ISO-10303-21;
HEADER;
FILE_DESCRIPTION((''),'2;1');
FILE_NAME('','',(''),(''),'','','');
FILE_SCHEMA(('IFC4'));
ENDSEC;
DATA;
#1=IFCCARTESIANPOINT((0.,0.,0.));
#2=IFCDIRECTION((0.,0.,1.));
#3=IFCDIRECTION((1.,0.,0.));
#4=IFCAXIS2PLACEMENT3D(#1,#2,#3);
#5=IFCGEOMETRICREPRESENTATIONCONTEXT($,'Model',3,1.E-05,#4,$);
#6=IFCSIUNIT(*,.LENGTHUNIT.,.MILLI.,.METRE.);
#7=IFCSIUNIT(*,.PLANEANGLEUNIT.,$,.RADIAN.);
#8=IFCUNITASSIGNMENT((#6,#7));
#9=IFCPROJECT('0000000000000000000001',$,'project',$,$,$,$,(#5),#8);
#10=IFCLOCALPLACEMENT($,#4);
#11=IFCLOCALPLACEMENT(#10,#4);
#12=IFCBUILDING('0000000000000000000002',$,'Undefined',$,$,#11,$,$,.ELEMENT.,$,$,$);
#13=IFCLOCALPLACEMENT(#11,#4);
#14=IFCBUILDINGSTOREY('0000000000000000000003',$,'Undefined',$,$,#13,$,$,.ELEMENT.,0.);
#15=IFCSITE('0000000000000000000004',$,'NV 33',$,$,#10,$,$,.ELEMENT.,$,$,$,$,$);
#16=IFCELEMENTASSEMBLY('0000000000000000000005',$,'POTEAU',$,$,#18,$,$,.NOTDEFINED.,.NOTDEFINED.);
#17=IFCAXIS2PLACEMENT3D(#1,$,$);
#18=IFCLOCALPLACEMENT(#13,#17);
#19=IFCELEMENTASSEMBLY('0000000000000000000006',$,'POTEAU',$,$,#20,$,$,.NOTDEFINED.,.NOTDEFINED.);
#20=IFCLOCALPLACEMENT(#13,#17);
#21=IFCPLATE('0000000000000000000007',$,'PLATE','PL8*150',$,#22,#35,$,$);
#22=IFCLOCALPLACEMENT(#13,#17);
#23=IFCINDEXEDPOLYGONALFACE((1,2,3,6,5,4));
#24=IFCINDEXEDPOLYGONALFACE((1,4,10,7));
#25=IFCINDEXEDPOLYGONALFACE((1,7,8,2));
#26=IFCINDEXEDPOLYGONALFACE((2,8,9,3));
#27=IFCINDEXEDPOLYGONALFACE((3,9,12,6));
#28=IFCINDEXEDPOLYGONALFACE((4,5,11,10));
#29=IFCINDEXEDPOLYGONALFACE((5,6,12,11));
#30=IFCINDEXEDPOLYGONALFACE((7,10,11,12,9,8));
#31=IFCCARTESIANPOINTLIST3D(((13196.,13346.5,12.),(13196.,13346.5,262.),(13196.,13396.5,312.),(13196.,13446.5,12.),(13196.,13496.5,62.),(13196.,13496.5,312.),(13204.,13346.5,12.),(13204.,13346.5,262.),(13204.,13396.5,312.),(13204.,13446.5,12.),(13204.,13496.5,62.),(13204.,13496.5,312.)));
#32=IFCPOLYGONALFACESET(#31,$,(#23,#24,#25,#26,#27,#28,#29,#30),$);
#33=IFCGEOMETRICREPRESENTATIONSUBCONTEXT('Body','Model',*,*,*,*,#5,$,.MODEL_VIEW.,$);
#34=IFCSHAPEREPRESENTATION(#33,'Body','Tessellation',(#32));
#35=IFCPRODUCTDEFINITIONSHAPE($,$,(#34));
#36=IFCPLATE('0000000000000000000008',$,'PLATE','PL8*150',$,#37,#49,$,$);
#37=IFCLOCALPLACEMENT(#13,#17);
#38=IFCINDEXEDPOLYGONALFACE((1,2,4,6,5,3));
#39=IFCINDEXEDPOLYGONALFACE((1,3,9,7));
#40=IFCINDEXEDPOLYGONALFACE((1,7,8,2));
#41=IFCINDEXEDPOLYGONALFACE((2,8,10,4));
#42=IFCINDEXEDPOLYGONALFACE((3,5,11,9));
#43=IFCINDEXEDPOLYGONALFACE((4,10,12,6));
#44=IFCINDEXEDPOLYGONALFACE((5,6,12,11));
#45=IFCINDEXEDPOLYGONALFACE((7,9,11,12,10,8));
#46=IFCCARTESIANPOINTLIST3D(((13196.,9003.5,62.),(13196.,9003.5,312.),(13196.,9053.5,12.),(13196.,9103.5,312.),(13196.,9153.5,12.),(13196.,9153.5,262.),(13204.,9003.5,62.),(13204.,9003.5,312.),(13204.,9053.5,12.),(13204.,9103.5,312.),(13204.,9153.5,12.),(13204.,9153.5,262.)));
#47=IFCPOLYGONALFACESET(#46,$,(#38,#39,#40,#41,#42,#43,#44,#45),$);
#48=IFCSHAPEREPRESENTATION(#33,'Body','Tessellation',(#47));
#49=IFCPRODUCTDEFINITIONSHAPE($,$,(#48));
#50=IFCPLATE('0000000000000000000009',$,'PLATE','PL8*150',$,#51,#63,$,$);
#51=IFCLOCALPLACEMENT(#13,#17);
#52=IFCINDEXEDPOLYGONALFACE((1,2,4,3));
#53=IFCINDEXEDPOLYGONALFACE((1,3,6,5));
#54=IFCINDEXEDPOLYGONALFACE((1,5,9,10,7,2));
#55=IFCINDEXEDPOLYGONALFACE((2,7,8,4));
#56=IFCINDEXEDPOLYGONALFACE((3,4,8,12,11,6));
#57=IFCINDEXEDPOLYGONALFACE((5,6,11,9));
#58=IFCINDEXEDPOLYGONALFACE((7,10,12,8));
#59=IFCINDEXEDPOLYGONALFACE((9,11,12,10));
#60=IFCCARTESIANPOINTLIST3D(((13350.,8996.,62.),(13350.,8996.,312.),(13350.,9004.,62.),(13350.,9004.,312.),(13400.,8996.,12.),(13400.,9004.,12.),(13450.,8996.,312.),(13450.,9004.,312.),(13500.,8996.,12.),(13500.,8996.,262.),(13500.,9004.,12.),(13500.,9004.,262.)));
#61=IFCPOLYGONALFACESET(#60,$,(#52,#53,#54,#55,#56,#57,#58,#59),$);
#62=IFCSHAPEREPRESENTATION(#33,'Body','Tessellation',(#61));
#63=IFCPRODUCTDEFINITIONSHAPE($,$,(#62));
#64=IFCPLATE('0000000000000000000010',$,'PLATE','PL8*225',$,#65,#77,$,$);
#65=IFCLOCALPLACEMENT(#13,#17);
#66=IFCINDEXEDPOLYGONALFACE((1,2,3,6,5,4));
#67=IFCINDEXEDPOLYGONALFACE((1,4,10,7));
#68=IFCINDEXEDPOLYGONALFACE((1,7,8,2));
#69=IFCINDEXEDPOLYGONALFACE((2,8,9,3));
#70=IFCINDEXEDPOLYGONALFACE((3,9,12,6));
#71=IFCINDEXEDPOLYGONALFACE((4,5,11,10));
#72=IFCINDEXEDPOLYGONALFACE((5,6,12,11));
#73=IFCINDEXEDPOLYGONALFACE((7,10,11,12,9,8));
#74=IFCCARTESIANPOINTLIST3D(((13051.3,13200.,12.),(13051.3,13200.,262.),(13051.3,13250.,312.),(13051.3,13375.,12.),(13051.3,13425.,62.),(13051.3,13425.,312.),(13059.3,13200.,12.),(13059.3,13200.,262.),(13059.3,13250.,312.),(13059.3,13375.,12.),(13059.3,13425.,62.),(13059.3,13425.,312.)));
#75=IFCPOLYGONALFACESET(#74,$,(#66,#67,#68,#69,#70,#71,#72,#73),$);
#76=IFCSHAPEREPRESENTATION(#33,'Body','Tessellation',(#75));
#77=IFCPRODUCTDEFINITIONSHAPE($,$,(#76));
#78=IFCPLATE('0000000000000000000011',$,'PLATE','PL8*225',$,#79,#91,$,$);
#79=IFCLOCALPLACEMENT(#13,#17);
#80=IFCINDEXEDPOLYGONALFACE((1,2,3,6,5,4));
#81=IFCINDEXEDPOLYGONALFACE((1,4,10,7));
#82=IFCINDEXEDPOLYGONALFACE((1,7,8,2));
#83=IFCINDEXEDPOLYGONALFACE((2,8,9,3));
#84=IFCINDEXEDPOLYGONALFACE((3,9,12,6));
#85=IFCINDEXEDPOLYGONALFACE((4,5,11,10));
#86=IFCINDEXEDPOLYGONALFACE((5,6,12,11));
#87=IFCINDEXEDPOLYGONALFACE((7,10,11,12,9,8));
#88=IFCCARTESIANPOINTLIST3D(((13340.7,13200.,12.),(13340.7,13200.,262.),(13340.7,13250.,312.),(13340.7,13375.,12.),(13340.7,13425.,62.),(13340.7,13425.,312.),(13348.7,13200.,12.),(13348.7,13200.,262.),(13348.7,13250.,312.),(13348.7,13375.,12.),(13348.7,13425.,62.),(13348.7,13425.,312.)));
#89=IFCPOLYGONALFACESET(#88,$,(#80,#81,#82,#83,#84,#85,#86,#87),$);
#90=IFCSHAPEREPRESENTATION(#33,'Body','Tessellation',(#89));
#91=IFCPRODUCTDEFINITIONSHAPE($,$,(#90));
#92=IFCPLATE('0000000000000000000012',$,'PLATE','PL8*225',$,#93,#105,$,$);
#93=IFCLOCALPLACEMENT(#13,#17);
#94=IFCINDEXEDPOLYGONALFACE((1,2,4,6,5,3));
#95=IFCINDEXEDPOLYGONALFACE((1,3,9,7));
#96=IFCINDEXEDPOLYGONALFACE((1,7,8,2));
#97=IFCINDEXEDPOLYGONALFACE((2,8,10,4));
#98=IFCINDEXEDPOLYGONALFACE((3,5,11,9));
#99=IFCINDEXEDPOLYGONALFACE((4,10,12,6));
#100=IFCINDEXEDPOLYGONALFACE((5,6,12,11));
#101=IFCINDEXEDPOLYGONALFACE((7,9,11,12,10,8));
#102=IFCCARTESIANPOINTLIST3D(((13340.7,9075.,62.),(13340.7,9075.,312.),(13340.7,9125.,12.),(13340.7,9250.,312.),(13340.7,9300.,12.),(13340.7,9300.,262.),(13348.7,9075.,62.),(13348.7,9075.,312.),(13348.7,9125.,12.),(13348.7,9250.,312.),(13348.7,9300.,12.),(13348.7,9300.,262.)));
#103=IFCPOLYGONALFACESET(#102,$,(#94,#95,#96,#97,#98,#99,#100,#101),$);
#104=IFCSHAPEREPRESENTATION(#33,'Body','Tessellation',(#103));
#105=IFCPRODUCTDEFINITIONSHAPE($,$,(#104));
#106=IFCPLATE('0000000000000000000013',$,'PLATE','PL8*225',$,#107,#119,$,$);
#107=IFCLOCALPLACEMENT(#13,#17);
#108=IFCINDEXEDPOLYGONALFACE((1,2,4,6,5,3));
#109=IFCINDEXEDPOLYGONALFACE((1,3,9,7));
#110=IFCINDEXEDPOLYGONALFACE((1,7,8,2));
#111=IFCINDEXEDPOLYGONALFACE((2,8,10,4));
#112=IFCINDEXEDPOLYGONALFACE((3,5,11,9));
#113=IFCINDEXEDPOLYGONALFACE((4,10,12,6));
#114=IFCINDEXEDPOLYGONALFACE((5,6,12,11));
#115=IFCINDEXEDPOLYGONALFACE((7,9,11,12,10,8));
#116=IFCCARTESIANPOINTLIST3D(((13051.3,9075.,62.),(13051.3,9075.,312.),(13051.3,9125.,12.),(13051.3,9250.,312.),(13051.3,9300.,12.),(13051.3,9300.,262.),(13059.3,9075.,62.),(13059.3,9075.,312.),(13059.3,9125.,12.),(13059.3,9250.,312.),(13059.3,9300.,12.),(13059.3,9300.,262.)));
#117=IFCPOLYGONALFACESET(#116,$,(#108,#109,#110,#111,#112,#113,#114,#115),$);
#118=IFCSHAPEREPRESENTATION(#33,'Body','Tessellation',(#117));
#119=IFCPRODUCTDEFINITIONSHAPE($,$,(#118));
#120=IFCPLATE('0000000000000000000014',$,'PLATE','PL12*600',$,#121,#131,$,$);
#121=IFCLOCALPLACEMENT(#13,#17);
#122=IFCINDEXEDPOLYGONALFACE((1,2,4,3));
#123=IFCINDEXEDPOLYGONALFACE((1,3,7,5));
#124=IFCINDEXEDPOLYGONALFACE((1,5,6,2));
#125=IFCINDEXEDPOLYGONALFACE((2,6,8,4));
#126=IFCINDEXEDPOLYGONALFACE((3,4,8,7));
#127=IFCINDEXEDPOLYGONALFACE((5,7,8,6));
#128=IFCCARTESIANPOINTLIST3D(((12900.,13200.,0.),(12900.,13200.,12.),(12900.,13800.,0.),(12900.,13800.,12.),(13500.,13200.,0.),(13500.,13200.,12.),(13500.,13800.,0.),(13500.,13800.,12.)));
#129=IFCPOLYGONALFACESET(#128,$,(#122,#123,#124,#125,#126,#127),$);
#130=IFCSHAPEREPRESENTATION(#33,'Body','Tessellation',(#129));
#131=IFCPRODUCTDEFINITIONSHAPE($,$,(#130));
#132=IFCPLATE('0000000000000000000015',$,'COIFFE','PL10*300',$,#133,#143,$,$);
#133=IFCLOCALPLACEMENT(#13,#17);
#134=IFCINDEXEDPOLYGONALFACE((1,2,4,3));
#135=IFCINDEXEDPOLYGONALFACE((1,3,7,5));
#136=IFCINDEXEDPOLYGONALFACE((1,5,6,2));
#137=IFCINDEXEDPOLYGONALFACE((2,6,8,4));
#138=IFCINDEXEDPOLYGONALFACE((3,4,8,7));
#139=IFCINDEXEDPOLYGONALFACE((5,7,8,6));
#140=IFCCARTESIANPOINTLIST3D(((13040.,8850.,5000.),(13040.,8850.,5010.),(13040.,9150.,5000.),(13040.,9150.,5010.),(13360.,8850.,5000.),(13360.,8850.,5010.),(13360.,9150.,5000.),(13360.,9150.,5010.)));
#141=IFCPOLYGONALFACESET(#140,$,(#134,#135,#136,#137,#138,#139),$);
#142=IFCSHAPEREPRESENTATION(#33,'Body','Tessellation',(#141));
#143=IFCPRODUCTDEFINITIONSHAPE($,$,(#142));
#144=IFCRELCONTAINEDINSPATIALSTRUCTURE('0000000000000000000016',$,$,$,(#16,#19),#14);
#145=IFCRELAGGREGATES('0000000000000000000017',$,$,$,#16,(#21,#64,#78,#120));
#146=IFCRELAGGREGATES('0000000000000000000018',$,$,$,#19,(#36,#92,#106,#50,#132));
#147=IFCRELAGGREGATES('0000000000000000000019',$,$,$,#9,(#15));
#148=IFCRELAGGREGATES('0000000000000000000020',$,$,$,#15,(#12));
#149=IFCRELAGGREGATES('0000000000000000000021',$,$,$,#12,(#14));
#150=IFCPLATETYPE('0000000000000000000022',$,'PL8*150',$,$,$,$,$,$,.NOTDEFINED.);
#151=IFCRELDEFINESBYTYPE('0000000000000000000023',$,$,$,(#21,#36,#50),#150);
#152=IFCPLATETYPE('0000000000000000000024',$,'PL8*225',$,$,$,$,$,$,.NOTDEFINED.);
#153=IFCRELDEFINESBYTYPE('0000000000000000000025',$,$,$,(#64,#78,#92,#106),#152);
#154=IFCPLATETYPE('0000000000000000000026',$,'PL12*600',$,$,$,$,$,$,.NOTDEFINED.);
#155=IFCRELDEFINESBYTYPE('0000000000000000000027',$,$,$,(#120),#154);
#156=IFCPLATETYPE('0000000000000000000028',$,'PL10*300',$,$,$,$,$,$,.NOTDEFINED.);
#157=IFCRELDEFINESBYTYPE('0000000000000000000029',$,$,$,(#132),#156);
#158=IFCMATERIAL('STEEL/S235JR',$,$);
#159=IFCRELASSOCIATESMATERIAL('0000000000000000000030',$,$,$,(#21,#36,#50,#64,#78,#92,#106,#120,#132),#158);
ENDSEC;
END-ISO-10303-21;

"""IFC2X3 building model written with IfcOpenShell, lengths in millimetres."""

from ifc_helpers import new_model, si_unit, frame, origin_with_axes, place, context, subcontext, project, spatial, polyline, outline, extrude, material, type_object, element, aggregate, save


model = new_model("IFC2X3")

# Units and contexts
model_context = context("Model", 3, precision=1e-05, world=origin_with_axes())
body_context = subcontext(model_context, "Body", "Model", "MODEL_VIEW")
ifc_project = project(units=[si_unit("LENGTHUNIT", "METRE", prefix="MILLI"), si_unit("PLANEANGLEUNIT", "RADIAN")], contexts=[model_context])

# Site, building, storey
site_placement = place(None, origin_with_axes())
site = spatial("IfcSite", under=ifc_project, at=site_placement, Name="NV 33", CompositionType="ELEMENT")
building_placement = place(site_placement, origin_with_axes())
building = spatial("IfcBuilding", under=site, at=building_placement, Name="Undefined", CompositionType="ELEMENT")
storey_placement = place(building_placement, origin_with_axes())
storey = spatial("IfcBuildingStorey", under=building, at=storey_placement, Name="Undefined", CompositionType="ELEMENT", Elevation=0.0)

# Shared definitions
ifc_material_1 = material(Name="STEEL/S235JR")

# Element assemblies
assembly_1_placement = place(storey_placement, origin_with_axes())
assembly_1 = element("IfcElementAssembly", 1, at=assembly_1_placement, inside=storey, Name="POTEAU", AssemblyPlace="NOTDEFINED", PredefinedType="NOTDEFINED")
assembly_2_placement = place(storey_placement, origin_with_axes())
assembly_2 = element("IfcElementAssembly", 2, at=assembly_2_placement, inside=storey, Name="POTEAU", AssemblyPlace="NOTDEFINED", PredefinedType="NOTDEFINED")

# Plates
plate_type_1 = type_object("IfcPlateType", Name="PL8*150", PredefinedType="NOTDEFINED")
plate_1_placement = place(assembly_1_placement, frame((13200.0, 13496.5, 12.0), z_axis=(-1.0, 0.0, 0.0), x_axis=(0.0, -1.0, 0.0)))
plate_1 = element("IfcPlate", 3, at=plate_1_placement, type_object=plate_type_1, material=ifc_material_1, Name="PLATE", Description="PL8*150", context=body_context, shape_type="SweptSolid", body=[
    extrude(outline(polyline([(0.0, 50.0), (50.0, 0.0), (150.0, 0.0), (150.0, 250.0), (100.0, 300.0), (0.0, 300.0), (0.0, 50.0)])), frame((0.0, 0.0, -4.0), z_axis=(0.0, 0.0, 1.0), x_axis=(1.0, 0.0, 0.0)), (0.0, 0.0, 1.0), 8.0),
])
plate_2_placement = place(assembly_2_placement, frame((13200.0, 9003.5, 12.0), z_axis=(1.0, 0.0, 0.0), x_axis=(0.0, 1.0, 0.0)))
plate_2 = element("IfcPlate", 4, at=plate_2_placement, type_object=plate_type_1, material=ifc_material_1, Name="PLATE", Description="PL8*150", context=body_context, shape_type="SweptSolid", body=[
    extrude(outline(polyline([(0.0, 50.0), (50.0, 0.0), (150.0, 0.0), (150.0, 250.0), (100.0, 300.0), (0.0, 300.0), (0.0, 50.0)])), frame((0.0, 0.0, -4.0), z_axis=(0.0, 0.0, 1.0), x_axis=(1.0, 0.0, 0.0)), (0.0, 0.0, 1.0), 8.0),
])
plate_3_placement = place(assembly_2_placement, frame((13350.0, 9000.0, 12.0), z_axis=(0.0, -1.0, 0.0), x_axis=(1.0, 0.0, 0.0)))
plate_3 = element("IfcPlate", 5, at=plate_3_placement, type_object=plate_type_1, material=ifc_material_1, Name="PLATE", Description="PL8*150", context=body_context, shape_type="SweptSolid", body=[
    extrude(outline(polyline([(0.0, 50.0), (50.0, 0.0), (150.0, 0.0), (150.0, 250.0), (100.0, 300.0), (0.0, 300.0), (0.0, 50.0)])), frame((0.0, 0.0, -4.0), z_axis=(0.0, 0.0, 1.0), x_axis=(1.0, 0.0, 0.0)), (0.0, 0.0, 1.0), 8.0),
])
plate_type_2 = type_object("IfcPlateType", Name="PL8*225", PredefinedType="NOTDEFINED")
plate_4_placement = place(assembly_1_placement, frame((13055.3, 13425.0, 12.0), z_axis=(-1.0, 0.0, 0.0), x_axis=(0.0, -1.0, 0.0)))
plate_4 = element("IfcPlate", 6, at=plate_4_placement, type_object=plate_type_2, material=ifc_material_1, Name="PLATE", Description="PL8*225", context=body_context, shape_type="SweptSolid", body=[
    extrude(outline(polyline([(0.0, 50.0), (50.0, 0.0), (225.0, 0.0), (225.0, 250.0), (175.0, 300.0), (0.0, 300.0), (0.0, 50.0)])), frame((0.0, 0.0, -4.0), z_axis=(0.0, 0.0, 1.0), x_axis=(1.0, 0.0, 0.0)), (0.0, 0.0, 1.0), 8.0),
])
plate_5_placement = place(assembly_1_placement, frame((13344.7, 13425.0, 12.0), z_axis=(-1.0, 0.0, 0.0), x_axis=(0.0, -1.0, 0.0)))
plate_5 = element("IfcPlate", 7, at=plate_5_placement, type_object=plate_type_2, material=ifc_material_1, Name="PLATE", Description="PL8*225", context=body_context, shape_type="SweptSolid", body=[
    extrude(outline(polyline([(0.0, 50.0), (50.0, 0.0), (225.0, 0.0), (225.0, 250.0), (175.0, 300.0), (0.0, 300.0), (0.0, 50.0)])), frame((0.0, 0.0, -4.0), z_axis=(0.0, 0.0, 1.0), x_axis=(1.0, 0.0, 0.0)), (0.0, 0.0, 1.0), 8.0),
])
plate_6_placement = place(assembly_2_placement, frame((13344.7, 9075.0, 12.0), z_axis=(1.0, 0.0, 0.0), x_axis=(0.0, 1.0, 0.0)))
plate_6 = element("IfcPlate", 8, at=plate_6_placement, type_object=plate_type_2, material=ifc_material_1, Name="PLATE", Description="PL8*225", context=body_context, shape_type="SweptSolid", body=[
    extrude(outline(polyline([(0.0, 50.0), (50.0, 0.0), (225.0, 0.0), (225.0, 250.0), (175.0, 300.0), (0.0, 300.0), (0.0, 50.0)])), frame((0.0, 0.0, -4.0), z_axis=(0.0, 0.0, 1.0), x_axis=(1.0, 0.0, 0.0)), (0.0, 0.0, 1.0), 8.0),
])
plate_7_placement = place(assembly_2_placement, frame((13055.3, 9075.0, 12.0), z_axis=(1.0, 0.0, 0.0), x_axis=(0.0, 1.0, 0.0)))
plate_7 = element("IfcPlate", 9, at=plate_7_placement, type_object=plate_type_2, material=ifc_material_1, Name="PLATE", Description="PL8*225", context=body_context, shape_type="SweptSolid", body=[
    extrude(outline(polyline([(0.0, 50.0), (50.0, 0.0), (225.0, 0.0), (225.0, 250.0), (175.0, 300.0), (0.0, 300.0), (0.0, 50.0)])), frame((0.0, 0.0, -4.0), z_axis=(0.0, 0.0, 1.0), x_axis=(1.0, 0.0, 0.0)), (0.0, 0.0, 1.0), 8.0),
])
plate_type_3 = type_object("IfcPlateType", Name="PL12*600", PredefinedType="NOTDEFINED")
plate_8_placement = place(assembly_1_placement, frame((12900.0, 13200.0, 6.0), z_axis=(0.0, 0.0, 1.0), x_axis=(1.0, 0.0, 0.0)))
plate_8 = element("IfcPlate", 10, at=plate_8_placement, type_object=plate_type_3, material=ifc_material_1, Name="PLATE", Description="PL12*600", context=body_context, shape_type="SweptSolid", body=[
    extrude(outline(polyline([(0.0, 0.0), (600.0, 0.0), (600.0, 600.0), (0.0, 600.0), (0.0, 0.0)])), frame((0.0, 0.0, -6.0), z_axis=(0.0, 0.0, 1.0), x_axis=(1.0, 0.0, 0.0)), (0.0, 0.0, 1.0), 12.0),
])
aggregate(assembly_1, [plate_1, plate_4, plate_5, plate_8])
plate_type_4 = type_object("IfcPlateType", Name="PL10*300", PredefinedType="NOTDEFINED")
plate_9_placement = place(assembly_2_placement, frame((13040.0, 9150.0, 5005.0), z_axis=(0.0, 0.0, 1.0), x_axis=(0.0, -1.0, 0.0)))
plate_9 = element("IfcPlate", 11, at=plate_9_placement, type_object=plate_type_4, material=ifc_material_1, Name="COIFFE", Description="PL10*300", context=body_context, shape_type="SweptSolid", body=[
    extrude(outline(polyline([(0.0, 0.0), (300.0, 0.0), (300.0, 320.0), (0.0, 320.0), (0.0, 0.0)])), frame((0.0, 0.0, -5.0), z_axis=(0.0, 0.0, 1.0), x_axis=(1.0, 0.0, 0.0)), (0.0, 0.0, 1.0), 10.0),
])
aggregate(assembly_2, [plate_2, plate_6, plate_7, plate_3, plate_9])

save(model, "model.ifc")
